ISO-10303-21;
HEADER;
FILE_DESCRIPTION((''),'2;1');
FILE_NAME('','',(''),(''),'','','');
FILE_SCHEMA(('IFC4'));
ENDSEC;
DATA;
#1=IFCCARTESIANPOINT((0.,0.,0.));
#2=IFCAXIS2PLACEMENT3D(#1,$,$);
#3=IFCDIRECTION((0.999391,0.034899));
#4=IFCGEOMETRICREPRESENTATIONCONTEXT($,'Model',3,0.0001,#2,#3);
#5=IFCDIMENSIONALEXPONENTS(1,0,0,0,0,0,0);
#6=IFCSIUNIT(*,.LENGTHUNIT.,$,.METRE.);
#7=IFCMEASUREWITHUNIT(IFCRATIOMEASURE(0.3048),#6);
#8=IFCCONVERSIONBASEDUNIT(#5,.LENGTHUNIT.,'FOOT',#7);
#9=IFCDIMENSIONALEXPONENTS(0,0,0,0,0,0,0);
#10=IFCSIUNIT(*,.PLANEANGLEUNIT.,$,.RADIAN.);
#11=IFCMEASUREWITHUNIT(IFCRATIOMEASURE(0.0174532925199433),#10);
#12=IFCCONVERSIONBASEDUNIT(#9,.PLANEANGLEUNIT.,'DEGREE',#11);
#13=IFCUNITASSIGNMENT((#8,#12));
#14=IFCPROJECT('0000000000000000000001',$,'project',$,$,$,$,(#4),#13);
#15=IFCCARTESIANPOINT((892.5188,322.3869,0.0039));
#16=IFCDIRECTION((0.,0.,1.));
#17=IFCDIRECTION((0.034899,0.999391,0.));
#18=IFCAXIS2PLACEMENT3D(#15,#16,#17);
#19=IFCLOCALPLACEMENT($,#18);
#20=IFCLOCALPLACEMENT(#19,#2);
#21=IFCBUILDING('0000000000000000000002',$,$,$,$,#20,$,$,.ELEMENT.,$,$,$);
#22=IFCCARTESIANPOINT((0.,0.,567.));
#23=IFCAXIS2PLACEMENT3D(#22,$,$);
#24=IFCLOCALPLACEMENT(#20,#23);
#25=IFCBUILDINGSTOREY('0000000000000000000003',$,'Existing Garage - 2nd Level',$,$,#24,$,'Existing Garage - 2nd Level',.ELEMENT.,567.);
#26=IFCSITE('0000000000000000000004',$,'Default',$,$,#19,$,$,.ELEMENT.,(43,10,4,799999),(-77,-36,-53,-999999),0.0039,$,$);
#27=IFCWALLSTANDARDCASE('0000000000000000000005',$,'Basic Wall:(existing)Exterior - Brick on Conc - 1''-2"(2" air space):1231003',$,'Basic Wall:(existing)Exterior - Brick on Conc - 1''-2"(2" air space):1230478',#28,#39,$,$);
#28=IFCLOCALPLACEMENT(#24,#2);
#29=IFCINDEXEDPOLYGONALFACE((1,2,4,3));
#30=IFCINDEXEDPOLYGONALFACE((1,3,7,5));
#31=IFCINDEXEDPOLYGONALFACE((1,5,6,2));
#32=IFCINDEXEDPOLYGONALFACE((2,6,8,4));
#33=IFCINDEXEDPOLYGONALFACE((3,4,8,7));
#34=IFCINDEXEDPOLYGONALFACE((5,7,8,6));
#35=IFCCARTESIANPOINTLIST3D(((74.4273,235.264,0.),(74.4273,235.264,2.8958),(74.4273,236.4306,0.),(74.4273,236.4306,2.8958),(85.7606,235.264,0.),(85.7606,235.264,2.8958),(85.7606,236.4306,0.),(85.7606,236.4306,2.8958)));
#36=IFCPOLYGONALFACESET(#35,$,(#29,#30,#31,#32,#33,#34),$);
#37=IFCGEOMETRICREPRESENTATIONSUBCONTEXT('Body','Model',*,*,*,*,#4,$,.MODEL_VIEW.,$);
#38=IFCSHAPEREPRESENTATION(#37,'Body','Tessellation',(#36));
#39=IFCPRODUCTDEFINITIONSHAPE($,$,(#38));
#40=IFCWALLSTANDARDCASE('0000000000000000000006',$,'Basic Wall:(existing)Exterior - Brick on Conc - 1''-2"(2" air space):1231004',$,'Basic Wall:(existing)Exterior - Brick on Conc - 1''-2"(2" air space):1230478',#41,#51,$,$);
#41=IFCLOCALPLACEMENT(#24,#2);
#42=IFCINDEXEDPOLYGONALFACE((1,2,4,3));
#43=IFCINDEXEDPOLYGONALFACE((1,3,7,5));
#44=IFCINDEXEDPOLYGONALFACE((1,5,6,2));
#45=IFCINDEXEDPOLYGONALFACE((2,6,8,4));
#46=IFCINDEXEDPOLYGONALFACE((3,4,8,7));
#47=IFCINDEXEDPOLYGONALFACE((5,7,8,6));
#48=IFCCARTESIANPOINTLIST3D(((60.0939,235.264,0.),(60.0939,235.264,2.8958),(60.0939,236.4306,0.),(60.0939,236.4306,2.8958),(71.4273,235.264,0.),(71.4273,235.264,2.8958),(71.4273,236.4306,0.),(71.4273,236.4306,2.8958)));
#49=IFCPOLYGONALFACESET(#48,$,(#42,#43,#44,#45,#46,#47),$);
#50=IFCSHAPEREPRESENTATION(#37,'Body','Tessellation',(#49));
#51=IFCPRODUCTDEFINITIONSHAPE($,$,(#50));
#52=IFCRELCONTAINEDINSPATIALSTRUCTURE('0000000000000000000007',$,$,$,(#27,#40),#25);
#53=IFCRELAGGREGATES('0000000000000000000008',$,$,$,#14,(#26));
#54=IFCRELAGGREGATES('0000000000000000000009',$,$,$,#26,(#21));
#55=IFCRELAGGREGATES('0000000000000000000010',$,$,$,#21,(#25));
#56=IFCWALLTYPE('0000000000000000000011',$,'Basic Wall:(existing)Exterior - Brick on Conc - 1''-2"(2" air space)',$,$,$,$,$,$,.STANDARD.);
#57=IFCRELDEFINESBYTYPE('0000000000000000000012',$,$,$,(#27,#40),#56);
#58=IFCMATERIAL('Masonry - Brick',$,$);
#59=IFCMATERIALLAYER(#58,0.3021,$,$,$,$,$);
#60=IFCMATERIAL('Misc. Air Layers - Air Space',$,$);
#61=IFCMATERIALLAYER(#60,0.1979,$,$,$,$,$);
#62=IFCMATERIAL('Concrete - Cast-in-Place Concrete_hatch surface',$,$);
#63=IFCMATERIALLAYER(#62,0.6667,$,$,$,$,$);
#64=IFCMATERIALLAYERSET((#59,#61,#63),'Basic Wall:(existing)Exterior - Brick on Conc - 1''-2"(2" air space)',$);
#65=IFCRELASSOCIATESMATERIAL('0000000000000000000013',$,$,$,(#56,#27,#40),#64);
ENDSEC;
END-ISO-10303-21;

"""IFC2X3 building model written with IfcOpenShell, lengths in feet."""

from ifc_helpers import new_model, entity, si_unit, converted_unit, direction, frame, frame_2d, origin, place, context, subcontext, project, spatial, rectangle, extrude, material, layer, layer_set, layer_usage, type_object, element, save


model = new_model("IFC2X3")

# Units and contexts
model_context = context("Model", 3, precision=0.0001, world=origin(), true_north=direction((0.999391, 0.034899)))
body_context = subcontext(model_context, "Body", "Model", "MODEL_VIEW")
ifc_project = project(units=[converted_unit("LENGTHUNIT", "FOOT", entity("IfcRatioMeasure", 0.3048), si_unit("LENGTHUNIT", "METRE"), dimensions=[1, 0, 0, 0, 0, 0, 0]), converted_unit("PLANEANGLEUNIT", "DEGREE", entity("IfcRatioMeasure", 0.0174532925199433), si_unit("PLANEANGLEUNIT", "RADIAN"), dimensions=[0, 0, 0, 0, 0, 0, 0])], contexts=[model_context])

# Site, building, storey
site_placement = place(None, frame((892.5188, 322.3869, 0.0039), z_axis=(0.0, 0.0, 1.0), x_axis=(0.034899, 0.999391, 0.0)))
site = spatial("IfcSite", under=ifc_project, at=site_placement, Name="Default", CompositionType="ELEMENT", RefLatitude=(43, 10, 4, 799999), RefLongitude=(-77, -36, -53, -999999), RefElevation=0.0039)
building_placement = place(site_placement, origin())
building = spatial("IfcBuilding", under=site, at=building_placement, CompositionType="ELEMENT")
storey_placement = place(building_placement, frame((0.0, 0.0, 567.0)))
storey = spatial("IfcBuildingStorey", under=building, at=storey_placement, Name="Existing Garage - 2nd Level", LongName="Existing Garage - 2nd Level", CompositionType="ELEMENT", Elevation=567.0)

# Shared definitions
ifc_material_1 = material(Name="Masonry - Brick")

# Walls
ifc_layer_1 = layer(ifc_material_1, 0.3021)
ifc_material_2 = material(Name="Misc. Air Layers - Air Space")
ifc_layer_2 = layer(ifc_material_2, 0.1979)
ifc_material_3 = material(Name="Concrete - Cast-in-Place Concrete_hatch surface")
ifc_layer_3 = layer(ifc_material_3, 0.6667)
ifc_layer_set_1 = layer_set([ifc_layer_1, ifc_layer_2, ifc_layer_3], Name="Basic Wall:(existing)Exterior - Brick on Conc - 1'-2\"(2\" air space)")
ifc_layer_usage_1 = layer_usage(ifc_layer_set_1, "AXIS2", "POSITIVE", -0.5833)
wall_type_1 = type_object("IfcWallType", Name="Basic Wall:(existing)Exterior - Brick on Conc - 1'-2\"(2\" air space)", PredefinedType="STANDARD", material=ifc_layer_set_1)
wall_1_placement = place(storey_placement, frame((74.4273, 235.8473, 0.0)))
element("IfcWallStandardCase", 1, at=wall_1_placement, inside=storey, type_object=wall_type_1, material=ifc_layer_usage_1, Name="Basic Wall:(existing)Exterior - Brick on Conc - 1'-2\"(2\" air space):1231003", ObjectType="Basic Wall:(existing)Exterior - Brick on Conc - 1'-2\"(2\" air space):1230478", context=body_context, shape_type="SweptSolid", body=[
    extrude(rectangle(XDim=11.3333, YDim=1.1667, at=frame_2d((5.6667, 0.0), x_axis=(-1.0, 0.0))), origin(), (0.0, 0.0, 1.0), 2.8958),
])
ifc_layer_usage_2 = layer_usage(ifc_layer_set_1, "AXIS2", "POSITIVE", -0.5833)
wall_2_placement = place(storey_placement, frame((60.0939, 235.8473, 0.0)))
element("IfcWallStandardCase", 2, at=wall_2_placement, inside=storey, type_object=wall_type_1, material=ifc_layer_usage_2, Name="Basic Wall:(existing)Exterior - Brick on Conc - 1'-2\"(2\" air space):1231004", ObjectType="Basic Wall:(existing)Exterior - Brick on Conc - 1'-2\"(2\" air space):1230478", context=body_context, shape_type="SweptSolid", body=[
    extrude(rectangle(XDim=11.3334, YDim=1.1667, at=frame_2d((5.6667, 0.0), x_axis=(-1.0, 0.0))), origin(), (0.0, 0.0, 1.0), 2.8958),
])

save(model, "model.ifc")
